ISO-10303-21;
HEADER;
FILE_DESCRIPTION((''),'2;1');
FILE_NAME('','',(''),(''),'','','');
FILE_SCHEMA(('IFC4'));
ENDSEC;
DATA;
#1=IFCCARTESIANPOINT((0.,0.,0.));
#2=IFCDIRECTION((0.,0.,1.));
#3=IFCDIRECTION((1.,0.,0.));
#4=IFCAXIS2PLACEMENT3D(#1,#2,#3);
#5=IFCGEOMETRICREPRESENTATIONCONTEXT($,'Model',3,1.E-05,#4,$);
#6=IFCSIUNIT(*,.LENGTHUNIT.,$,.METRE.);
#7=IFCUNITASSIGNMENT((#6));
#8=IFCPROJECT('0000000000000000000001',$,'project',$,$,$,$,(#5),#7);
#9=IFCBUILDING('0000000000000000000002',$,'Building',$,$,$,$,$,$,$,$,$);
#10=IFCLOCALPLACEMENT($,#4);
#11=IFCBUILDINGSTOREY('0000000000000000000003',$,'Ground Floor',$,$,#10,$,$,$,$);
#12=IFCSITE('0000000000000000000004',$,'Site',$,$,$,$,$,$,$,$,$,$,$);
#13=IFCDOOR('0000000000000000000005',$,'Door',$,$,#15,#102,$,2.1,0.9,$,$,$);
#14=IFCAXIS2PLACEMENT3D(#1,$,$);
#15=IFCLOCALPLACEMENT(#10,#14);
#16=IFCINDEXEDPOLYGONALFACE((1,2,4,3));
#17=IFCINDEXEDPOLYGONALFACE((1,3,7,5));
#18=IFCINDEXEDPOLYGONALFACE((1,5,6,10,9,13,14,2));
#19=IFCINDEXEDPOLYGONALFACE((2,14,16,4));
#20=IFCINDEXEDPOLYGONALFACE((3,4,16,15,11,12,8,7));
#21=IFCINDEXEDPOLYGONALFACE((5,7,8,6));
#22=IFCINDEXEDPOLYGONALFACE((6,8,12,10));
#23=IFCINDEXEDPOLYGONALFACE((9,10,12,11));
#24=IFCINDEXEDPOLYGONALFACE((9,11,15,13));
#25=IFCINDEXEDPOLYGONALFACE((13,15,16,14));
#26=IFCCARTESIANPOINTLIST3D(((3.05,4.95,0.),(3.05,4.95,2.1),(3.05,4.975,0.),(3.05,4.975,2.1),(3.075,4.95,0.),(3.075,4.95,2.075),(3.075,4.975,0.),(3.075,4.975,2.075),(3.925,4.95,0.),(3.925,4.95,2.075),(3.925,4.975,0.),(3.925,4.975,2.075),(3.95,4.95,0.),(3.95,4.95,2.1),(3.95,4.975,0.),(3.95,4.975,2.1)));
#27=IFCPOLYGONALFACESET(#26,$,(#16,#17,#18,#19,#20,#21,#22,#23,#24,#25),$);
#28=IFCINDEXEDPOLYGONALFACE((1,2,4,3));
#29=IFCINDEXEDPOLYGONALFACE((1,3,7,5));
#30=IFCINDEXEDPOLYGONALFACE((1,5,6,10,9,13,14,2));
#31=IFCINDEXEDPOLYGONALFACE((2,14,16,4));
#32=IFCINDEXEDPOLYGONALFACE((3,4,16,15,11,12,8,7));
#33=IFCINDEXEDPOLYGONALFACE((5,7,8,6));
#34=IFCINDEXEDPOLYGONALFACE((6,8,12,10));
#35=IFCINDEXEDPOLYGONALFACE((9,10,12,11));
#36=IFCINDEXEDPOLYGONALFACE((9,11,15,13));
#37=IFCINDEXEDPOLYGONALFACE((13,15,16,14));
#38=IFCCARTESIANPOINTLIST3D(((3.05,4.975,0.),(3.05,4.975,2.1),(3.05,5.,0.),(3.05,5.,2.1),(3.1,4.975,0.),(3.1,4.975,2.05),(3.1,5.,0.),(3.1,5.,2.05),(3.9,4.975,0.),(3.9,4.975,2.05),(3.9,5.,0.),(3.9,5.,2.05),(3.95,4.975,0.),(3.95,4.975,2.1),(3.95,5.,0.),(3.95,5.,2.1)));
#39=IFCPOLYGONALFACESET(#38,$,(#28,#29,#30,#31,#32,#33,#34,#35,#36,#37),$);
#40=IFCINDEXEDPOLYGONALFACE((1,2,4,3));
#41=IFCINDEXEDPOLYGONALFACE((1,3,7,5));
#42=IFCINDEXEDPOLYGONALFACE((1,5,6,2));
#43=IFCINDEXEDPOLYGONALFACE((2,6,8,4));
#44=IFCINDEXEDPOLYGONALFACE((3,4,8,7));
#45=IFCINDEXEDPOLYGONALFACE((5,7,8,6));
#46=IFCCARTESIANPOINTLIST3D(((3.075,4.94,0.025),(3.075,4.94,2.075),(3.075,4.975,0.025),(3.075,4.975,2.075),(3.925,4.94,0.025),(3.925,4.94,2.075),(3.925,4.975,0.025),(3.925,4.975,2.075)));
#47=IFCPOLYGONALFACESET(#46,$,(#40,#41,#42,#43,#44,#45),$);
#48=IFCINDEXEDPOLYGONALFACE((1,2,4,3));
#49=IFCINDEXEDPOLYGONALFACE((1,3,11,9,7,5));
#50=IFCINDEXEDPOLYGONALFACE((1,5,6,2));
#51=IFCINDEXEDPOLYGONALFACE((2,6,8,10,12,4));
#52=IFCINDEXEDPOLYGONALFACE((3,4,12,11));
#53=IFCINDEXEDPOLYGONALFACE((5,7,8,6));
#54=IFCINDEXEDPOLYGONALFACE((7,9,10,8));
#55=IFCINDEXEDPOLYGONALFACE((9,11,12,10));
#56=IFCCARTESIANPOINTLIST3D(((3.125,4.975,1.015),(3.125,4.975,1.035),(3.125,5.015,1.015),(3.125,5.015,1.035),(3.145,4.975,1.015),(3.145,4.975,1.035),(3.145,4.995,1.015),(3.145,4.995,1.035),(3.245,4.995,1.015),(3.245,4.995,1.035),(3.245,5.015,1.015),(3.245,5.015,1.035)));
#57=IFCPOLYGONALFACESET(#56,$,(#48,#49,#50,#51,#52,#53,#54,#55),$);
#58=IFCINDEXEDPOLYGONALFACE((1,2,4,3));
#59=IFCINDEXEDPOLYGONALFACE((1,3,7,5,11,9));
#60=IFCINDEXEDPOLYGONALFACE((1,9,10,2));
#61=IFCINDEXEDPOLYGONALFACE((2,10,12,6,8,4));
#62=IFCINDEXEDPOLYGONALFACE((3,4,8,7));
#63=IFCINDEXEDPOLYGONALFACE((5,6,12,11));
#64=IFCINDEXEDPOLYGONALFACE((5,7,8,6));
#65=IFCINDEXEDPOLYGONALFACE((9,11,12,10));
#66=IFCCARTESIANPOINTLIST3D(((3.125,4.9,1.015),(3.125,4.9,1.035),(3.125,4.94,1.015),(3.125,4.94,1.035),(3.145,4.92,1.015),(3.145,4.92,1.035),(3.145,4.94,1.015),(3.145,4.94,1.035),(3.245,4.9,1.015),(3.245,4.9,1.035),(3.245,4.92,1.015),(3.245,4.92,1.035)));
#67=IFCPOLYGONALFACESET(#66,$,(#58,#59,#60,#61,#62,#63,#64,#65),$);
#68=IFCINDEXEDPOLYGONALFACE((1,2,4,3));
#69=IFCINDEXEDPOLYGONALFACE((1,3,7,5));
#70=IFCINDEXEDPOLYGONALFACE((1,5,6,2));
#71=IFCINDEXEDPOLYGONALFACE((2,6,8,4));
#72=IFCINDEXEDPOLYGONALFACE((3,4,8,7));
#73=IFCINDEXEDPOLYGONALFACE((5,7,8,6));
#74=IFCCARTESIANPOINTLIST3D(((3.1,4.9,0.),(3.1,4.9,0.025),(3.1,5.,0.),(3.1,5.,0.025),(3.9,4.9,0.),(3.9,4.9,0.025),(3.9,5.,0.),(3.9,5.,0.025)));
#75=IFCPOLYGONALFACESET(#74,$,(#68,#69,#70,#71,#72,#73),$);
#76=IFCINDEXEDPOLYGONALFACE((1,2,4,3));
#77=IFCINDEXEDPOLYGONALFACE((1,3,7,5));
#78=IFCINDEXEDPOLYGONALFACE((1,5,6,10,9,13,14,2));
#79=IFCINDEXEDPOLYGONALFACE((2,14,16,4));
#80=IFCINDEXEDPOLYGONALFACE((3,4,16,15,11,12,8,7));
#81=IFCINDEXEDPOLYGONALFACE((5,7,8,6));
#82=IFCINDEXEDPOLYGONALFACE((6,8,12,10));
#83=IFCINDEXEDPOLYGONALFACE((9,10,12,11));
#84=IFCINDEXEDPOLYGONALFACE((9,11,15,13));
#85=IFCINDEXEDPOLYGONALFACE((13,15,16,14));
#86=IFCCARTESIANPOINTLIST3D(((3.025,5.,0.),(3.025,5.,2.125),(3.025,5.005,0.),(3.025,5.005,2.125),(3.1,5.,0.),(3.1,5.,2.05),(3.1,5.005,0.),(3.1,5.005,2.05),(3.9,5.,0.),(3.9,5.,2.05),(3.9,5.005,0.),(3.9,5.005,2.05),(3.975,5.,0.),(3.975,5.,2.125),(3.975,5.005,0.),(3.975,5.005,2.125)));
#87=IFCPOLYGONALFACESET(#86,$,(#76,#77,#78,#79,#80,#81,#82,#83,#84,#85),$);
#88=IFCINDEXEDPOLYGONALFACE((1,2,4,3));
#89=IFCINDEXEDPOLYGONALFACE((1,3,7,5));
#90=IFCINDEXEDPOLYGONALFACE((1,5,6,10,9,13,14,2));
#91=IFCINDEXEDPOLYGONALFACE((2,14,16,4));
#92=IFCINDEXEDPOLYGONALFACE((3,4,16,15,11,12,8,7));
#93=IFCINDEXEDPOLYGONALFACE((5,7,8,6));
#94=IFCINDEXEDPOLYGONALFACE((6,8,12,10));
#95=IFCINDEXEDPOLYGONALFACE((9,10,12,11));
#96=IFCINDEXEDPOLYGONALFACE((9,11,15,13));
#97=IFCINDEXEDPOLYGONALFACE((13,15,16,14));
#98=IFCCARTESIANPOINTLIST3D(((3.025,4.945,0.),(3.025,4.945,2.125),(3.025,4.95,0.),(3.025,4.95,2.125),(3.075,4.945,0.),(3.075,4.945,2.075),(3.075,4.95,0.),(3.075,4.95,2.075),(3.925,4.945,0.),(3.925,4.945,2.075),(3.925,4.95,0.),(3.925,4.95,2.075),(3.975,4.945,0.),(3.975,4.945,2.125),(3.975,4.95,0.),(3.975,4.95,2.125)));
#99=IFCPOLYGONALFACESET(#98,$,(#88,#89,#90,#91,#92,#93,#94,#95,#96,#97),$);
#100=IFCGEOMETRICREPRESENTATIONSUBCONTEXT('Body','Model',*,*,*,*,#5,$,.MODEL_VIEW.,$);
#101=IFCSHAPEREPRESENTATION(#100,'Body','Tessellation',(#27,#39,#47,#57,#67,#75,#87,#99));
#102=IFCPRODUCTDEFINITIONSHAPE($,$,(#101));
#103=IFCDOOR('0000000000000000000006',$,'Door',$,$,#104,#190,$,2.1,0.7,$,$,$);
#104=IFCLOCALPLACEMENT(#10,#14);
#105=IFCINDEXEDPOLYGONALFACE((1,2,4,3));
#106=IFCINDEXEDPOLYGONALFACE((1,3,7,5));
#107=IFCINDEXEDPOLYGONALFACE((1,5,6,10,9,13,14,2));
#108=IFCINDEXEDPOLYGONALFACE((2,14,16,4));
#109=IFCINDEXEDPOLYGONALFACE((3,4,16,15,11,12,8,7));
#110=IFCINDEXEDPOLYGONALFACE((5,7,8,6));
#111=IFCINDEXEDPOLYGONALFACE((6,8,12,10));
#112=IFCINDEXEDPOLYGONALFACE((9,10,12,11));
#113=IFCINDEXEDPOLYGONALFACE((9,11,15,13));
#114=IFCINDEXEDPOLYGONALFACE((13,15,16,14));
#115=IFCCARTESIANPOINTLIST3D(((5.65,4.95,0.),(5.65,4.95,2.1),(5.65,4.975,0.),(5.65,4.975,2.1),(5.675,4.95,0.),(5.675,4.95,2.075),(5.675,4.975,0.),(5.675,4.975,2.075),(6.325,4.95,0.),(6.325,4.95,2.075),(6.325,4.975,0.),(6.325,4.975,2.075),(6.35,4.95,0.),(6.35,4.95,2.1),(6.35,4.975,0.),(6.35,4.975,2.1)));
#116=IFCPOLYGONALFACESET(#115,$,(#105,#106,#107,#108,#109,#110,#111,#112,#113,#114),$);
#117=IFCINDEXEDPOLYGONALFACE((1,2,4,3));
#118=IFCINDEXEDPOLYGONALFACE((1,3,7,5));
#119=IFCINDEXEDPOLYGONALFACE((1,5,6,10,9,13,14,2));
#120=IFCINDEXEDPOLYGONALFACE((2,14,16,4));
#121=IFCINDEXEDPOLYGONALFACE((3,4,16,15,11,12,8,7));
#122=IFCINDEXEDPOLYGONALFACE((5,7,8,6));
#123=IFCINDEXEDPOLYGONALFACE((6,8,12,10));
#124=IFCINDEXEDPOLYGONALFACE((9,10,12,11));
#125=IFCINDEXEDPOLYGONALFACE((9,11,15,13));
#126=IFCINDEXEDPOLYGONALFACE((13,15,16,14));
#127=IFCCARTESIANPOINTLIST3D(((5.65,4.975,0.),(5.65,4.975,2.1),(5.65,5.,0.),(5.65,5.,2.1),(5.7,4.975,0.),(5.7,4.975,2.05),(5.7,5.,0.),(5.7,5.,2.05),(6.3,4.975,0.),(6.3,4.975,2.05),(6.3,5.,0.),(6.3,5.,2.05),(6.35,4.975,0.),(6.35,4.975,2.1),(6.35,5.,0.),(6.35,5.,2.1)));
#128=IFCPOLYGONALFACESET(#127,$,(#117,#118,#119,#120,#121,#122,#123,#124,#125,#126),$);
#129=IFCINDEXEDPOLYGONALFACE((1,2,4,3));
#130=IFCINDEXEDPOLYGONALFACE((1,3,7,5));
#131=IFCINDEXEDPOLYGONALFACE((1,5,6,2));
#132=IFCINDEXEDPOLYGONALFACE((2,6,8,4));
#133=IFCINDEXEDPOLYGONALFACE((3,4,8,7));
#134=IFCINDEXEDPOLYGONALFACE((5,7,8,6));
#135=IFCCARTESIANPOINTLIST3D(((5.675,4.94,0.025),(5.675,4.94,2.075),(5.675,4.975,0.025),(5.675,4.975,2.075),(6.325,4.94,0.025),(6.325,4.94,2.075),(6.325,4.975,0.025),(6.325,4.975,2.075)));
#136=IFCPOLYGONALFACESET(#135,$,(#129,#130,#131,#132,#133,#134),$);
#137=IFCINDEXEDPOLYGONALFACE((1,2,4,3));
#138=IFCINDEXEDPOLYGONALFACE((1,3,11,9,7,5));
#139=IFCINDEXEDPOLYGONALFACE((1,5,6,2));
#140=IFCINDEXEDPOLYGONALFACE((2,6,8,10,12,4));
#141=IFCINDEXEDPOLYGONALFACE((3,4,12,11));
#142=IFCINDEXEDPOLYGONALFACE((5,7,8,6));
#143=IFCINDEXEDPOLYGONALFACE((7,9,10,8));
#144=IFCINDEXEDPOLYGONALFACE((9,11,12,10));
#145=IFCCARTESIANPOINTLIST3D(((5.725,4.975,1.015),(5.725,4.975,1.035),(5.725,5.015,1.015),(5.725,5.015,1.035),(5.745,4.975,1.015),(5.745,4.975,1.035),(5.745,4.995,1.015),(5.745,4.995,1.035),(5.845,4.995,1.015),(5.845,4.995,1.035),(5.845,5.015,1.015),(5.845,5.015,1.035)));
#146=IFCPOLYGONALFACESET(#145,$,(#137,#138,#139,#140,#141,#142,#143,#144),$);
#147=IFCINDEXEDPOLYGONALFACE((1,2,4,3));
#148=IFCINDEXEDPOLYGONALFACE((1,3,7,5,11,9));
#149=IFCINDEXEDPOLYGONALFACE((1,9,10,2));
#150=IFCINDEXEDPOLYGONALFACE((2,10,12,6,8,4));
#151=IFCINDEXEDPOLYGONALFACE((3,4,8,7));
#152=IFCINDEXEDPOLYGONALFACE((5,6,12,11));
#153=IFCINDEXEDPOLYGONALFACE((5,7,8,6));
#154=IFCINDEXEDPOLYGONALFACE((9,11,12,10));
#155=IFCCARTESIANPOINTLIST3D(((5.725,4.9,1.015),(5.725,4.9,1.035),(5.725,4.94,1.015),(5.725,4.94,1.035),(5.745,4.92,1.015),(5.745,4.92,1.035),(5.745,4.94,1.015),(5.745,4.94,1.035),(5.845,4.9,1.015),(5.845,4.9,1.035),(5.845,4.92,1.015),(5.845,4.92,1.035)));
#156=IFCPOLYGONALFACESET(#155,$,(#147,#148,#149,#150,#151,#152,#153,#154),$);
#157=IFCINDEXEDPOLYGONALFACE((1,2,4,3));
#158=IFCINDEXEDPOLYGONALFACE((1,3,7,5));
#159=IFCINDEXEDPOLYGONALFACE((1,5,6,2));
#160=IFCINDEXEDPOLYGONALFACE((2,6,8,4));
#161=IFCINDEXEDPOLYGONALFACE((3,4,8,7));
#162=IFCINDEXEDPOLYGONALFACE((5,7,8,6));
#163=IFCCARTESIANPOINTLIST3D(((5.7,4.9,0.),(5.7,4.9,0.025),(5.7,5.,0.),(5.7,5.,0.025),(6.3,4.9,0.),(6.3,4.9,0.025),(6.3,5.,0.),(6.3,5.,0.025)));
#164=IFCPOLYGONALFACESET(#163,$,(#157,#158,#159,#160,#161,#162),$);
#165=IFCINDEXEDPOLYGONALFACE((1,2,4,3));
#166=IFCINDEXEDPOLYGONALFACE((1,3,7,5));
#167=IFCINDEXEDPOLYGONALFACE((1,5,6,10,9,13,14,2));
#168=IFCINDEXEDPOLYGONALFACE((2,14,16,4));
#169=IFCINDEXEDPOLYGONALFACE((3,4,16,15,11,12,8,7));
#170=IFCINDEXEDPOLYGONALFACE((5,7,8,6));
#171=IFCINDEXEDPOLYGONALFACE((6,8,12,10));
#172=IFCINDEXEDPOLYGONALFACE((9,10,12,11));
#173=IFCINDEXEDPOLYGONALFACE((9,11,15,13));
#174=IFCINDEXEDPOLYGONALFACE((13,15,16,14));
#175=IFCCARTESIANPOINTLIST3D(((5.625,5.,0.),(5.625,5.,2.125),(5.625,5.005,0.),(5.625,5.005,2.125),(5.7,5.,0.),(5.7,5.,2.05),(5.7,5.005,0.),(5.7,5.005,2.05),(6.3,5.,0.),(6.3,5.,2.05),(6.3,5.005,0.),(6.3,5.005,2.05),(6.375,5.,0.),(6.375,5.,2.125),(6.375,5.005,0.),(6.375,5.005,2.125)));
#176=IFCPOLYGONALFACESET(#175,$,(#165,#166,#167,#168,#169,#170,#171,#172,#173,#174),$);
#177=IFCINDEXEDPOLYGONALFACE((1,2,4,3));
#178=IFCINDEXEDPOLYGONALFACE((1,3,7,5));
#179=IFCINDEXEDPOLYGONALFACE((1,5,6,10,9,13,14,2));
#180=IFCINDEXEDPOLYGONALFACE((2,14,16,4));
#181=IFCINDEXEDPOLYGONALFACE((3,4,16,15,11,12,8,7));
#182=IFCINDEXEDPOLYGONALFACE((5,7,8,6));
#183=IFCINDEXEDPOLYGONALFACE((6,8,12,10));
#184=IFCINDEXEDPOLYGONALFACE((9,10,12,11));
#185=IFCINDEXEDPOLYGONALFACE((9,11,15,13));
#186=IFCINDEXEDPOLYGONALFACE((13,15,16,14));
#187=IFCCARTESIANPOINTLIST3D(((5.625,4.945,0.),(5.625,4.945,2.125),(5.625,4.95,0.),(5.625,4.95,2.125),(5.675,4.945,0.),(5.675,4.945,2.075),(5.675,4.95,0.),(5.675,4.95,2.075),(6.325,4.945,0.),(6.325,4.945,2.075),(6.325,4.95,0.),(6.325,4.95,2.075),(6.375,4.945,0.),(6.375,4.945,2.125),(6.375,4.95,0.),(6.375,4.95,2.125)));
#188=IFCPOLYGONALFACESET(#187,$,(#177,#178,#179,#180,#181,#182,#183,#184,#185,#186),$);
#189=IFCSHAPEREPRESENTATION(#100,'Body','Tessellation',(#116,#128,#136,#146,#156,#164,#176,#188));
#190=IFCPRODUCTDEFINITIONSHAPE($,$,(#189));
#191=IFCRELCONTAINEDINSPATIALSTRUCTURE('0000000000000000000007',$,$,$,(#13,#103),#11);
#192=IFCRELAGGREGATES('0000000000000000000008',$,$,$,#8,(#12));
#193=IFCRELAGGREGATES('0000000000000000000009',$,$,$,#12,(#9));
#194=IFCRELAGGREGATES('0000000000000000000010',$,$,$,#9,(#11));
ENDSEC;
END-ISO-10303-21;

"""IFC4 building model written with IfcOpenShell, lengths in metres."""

from ifc_helpers import new_model, si_unit, frame, origin_with_axes, place, context, subcontext, project, spatial, line, indexed_curve, outline, extrude, element, save


model = new_model("IFC4")

# Units and contexts
model_context = context("Model", 3, precision=1e-05, world=origin_with_axes())
body_context = subcontext(model_context, "Body", "Model", "MODEL_VIEW")
ifc_project = project(units=[si_unit("LENGTHUNIT", "METRE")], contexts=[model_context])

# Site, building, storey
site = spatial("IfcSite", under=ifc_project, Name="Site")
building = spatial("IfcBuilding", under=site, Name="Building")
storey_placement = place(None, origin_with_axes())
storey = spatial("IfcBuildingStorey", under=building, at=storey_placement, Name="Ground Floor")

# Doors
door_1_placement = place(storey_placement, frame((3.95, 5.0, 0.0), z_axis=(0.0, 0.0, 1.0), x_axis=(-1.0, 0.0, 0.0)))
element("IfcDoor", 1, at=door_1_placement, inside=storey, Name="Door", OverallHeight=2.1, OverallWidth=0.9, context=body_context, shape_type="SweptSolid", body=[
    extrude(outline(indexed_curve([(0.0, 0.0), (0.0, 2.1), (0.9, 2.1), (0.9, 0.0), (0.875, 0.0), (0.875, 2.075), (0.025, 2.075), (0.025, 0.0)], segments=[line(1, 2, 3, 4, 5, 6, 7, 8, 1)])), frame((0.0, 0.025, 0.0), z_axis=(0.0, -1.0, 0.0), x_axis=(1.0, 0.0, 0.0)), (0.0, 0.0, -1.0), 0.025),
    extrude(outline(indexed_curve([(0.0, 0.0), (0.0, 2.1), (0.9, 2.1), (0.9, 0.0), (0.85, 0.0), (0.85, 2.05), (0.05, 2.05), (0.05, 0.0)], segments=[line(1, 2, 3, 4, 5, 6, 7, 8, 1)])), frame((0.0, 0.0, 0.0), z_axis=(0.0, -1.0, 0.0), x_axis=(1.0, 0.0, 0.0)), (0.0, 0.0, -1.0), 0.025),
    extrude(outline(indexed_curve([(0.0, 0.0), (0.85, 0.0), (0.85, 0.035), (0.0, 0.035)], segments=[line(1, 2, 3, 4, 1)])), frame((0.025, 0.025, 0.025), z_axis=(0.0, 0.0, 1.0), x_axis=(1.0, 0.0, 0.0)), (0.0, 0.0, 1.0), 2.05),
    extrude(outline(indexed_curve([(0.0, 0.0), (0.0, -0.04), (-0.12, -0.04), (-0.12, -0.02), (-0.02, -0.02), (-0.02, 0.0)], segments=[line(1, 2, 3, 4, 5, 6, 1)])), frame((0.825, 0.025, 1.015), z_axis=(0.0, 0.0, 1.0), x_axis=(1.0, 0.0, 0.0)), (0.0, 0.0, 1.0), 0.02),
    extrude(outline(indexed_curve([(0.0, 0.0), (0.0, 0.04), (-0.12, 0.04), (-0.12, 0.02), (-0.02, 0.02), (-0.02, 0.0)], segments=[line(1, 2, 3, 4, 5, 6, 1)])), frame((0.825, 0.06, 1.015), z_axis=(0.0, 0.0, 1.0), x_axis=(1.0, 0.0, 0.0)), (0.0, 0.0, 1.0), 0.02),
    extrude(outline(indexed_curve([(0.0, 0.0), (0.8, 0.0), (0.8, 0.1), (0.0, 0.1)], segments=[line(1, 2, 3, 4, 1)])), frame((0.05, 0.0, 0.0), z_axis=(0.0, 0.0, 1.0), x_axis=(1.0, 0.0, 0.0)), (0.0, 0.0, 1.0), 0.025),
    extrude(outline(indexed_curve([(0.0, 0.0), (0.0, 2.125), (0.95, 2.125), (0.95, 0.0), (0.875, 0.0), (0.875, 2.05), (0.075, 2.05), (0.075, 0.0)], segments=[line(1, 2, 3, 4, 5, 6, 7, 8, 1)])), frame((-0.025, -0.005, 0.0), z_axis=(0.0, -1.0, 0.0), x_axis=(1.0, 0.0, 0.0)), (0.0, 0.0, -1.0), 0.005),
    extrude(outline(indexed_curve([(0.0, 0.0), (0.0, 2.125), (0.95, 2.125), (0.95, 0.0), (0.9, 0.0), (0.9, 2.075), (0.05, 2.075), (0.05, 0.0)], segments=[line(1, 2, 3, 4, 5, 6, 7, 8, 1)])), frame((-0.025, 0.05, 0.0), z_axis=(0.0, -1.0, 0.0), x_axis=(1.0, 0.0, 0.0)), (0.0, 0.0, -1.0), 0.005),
])
door_2_placement = place(storey_placement, frame((6.35, 5.0, 0.0), z_axis=(0.0, 0.0, 1.0), x_axis=(-1.0, 0.0, 0.0)))
element("IfcDoor", 2, at=door_2_placement, inside=storey, Name="Door", OverallHeight=2.1, OverallWidth=0.7, context=body_context, shape_type="SweptSolid", body=[
    extrude(outline(indexed_curve([(0.0, 0.0), (0.0, 2.1), (0.7, 2.1), (0.7, 0.0), (0.675, 0.0), (0.675, 2.075), (0.025, 2.075), (0.025, 0.0)], segments=[line(1, 2, 3, 4, 5, 6, 7, 8, 1)])), frame((0.0, 0.025, 0.0), z_axis=(0.0, -1.0, 0.0), x_axis=(1.0, 0.0, 0.0)), (0.0, 0.0, -1.0), 0.025),
    extrude(outline(indexed_curve([(0.0, 0.0), (0.0, 2.1), (0.7, 2.1), (0.7, 0.0), (0.65, 0.0), (0.65, 2.05), (0.05, 2.05), (0.05, 0.0)], segments=[line(1, 2, 3, 4, 5, 6, 7, 8, 1)])), frame((0.0, 0.0, 0.0), z_axis=(0.0, -1.0, 0.0), x_axis=(1.0, 0.0, 0.0)), (0.0, 0.0, -1.0), 0.025),
    extrude(outline(indexed_curve([(0.0, 0.0), (0.65, 0.0), (0.65, 0.035), (0.0, 0.035)], segments=[line(1, 2, 3, 4, 1)])), frame((0.025, 0.025, 0.025), z_axis=(0.0, 0.0, 1.0), x_axis=(1.0, 0.0, 0.0)), (0.0, 0.0, 1.0), 2.05),
    extrude(outline(indexed_curve([(0.0, 0.0), (0.0, -0.04), (-0.12, -0.04), (-0.12, -0.02), (-0.02, -0.02), (-0.02, 0.0)], segments=[line(1, 2, 3, 4, 5, 6, 1)])), frame((0.625, 0.025, 1.015), z_axis=(0.0, 0.0, 1.0), x_axis=(1.0, 0.0, 0.0)), (0.0, 0.0, 1.0), 0.02),
    extrude(outline(indexed_curve([(0.0, 0.0), (0.0, 0.04), (-0.12, 0.04), (-0.12, 0.02), (-0.02, 0.02), (-0.02, 0.0)], segments=[line(1, 2, 3, 4, 5, 6, 1)])), frame((0.625, 0.06, 1.015), z_axis=(0.0, 0.0, 1.0), x_axis=(1.0, 0.0, 0.0)), (0.0, 0.0, 1.0), 0.02),
    extrude(outline(indexed_curve([(0.0, 0.0), (0.6, 0.0), (0.6, 0.1), (0.0, 0.1)], segments=[line(1, 2, 3, 4, 1)])), frame((0.05, 0.0, 0.0), z_axis=(0.0, 0.0, 1.0), x_axis=(1.0, 0.0, 0.0)), (0.0, 0.0, 1.0), 0.025),
    extrude(outline(indexed_curve([(0.0, 0.0), (0.0, 2.125), (0.75, 2.125), (0.75, 0.0), (0.675, 0.0), (0.675, 2.05), (0.075, 2.05), (0.075, 0.0)], segments=[line(1, 2, 3, 4, 5, 6, 7, 8, 1)])), frame((-0.025, -0.005, 0.0), z_axis=(0.0, -1.0, 0.0), x_axis=(1.0, 0.0, 0.0)), (0.0, 0.0, -1.0), 0.005),
    extrude(outline(indexed_curve([(0.0, 0.0), (0.0, 2.125), (0.75, 2.125), (0.75, 0.0), (0.7, 0.0), (0.7, 2.075), (0.05, 2.075), (0.05, 0.0)], segments=[line(1, 2, 3, 4, 5, 6, 7, 8, 1)])), frame((-0.025, 0.05, 0.0), z_axis=(0.0, -1.0, 0.0), x_axis=(1.0, 0.0, 0.0)), (0.0, 0.0, -1.0), 0.005),
])

save(model, "model.ifc")
